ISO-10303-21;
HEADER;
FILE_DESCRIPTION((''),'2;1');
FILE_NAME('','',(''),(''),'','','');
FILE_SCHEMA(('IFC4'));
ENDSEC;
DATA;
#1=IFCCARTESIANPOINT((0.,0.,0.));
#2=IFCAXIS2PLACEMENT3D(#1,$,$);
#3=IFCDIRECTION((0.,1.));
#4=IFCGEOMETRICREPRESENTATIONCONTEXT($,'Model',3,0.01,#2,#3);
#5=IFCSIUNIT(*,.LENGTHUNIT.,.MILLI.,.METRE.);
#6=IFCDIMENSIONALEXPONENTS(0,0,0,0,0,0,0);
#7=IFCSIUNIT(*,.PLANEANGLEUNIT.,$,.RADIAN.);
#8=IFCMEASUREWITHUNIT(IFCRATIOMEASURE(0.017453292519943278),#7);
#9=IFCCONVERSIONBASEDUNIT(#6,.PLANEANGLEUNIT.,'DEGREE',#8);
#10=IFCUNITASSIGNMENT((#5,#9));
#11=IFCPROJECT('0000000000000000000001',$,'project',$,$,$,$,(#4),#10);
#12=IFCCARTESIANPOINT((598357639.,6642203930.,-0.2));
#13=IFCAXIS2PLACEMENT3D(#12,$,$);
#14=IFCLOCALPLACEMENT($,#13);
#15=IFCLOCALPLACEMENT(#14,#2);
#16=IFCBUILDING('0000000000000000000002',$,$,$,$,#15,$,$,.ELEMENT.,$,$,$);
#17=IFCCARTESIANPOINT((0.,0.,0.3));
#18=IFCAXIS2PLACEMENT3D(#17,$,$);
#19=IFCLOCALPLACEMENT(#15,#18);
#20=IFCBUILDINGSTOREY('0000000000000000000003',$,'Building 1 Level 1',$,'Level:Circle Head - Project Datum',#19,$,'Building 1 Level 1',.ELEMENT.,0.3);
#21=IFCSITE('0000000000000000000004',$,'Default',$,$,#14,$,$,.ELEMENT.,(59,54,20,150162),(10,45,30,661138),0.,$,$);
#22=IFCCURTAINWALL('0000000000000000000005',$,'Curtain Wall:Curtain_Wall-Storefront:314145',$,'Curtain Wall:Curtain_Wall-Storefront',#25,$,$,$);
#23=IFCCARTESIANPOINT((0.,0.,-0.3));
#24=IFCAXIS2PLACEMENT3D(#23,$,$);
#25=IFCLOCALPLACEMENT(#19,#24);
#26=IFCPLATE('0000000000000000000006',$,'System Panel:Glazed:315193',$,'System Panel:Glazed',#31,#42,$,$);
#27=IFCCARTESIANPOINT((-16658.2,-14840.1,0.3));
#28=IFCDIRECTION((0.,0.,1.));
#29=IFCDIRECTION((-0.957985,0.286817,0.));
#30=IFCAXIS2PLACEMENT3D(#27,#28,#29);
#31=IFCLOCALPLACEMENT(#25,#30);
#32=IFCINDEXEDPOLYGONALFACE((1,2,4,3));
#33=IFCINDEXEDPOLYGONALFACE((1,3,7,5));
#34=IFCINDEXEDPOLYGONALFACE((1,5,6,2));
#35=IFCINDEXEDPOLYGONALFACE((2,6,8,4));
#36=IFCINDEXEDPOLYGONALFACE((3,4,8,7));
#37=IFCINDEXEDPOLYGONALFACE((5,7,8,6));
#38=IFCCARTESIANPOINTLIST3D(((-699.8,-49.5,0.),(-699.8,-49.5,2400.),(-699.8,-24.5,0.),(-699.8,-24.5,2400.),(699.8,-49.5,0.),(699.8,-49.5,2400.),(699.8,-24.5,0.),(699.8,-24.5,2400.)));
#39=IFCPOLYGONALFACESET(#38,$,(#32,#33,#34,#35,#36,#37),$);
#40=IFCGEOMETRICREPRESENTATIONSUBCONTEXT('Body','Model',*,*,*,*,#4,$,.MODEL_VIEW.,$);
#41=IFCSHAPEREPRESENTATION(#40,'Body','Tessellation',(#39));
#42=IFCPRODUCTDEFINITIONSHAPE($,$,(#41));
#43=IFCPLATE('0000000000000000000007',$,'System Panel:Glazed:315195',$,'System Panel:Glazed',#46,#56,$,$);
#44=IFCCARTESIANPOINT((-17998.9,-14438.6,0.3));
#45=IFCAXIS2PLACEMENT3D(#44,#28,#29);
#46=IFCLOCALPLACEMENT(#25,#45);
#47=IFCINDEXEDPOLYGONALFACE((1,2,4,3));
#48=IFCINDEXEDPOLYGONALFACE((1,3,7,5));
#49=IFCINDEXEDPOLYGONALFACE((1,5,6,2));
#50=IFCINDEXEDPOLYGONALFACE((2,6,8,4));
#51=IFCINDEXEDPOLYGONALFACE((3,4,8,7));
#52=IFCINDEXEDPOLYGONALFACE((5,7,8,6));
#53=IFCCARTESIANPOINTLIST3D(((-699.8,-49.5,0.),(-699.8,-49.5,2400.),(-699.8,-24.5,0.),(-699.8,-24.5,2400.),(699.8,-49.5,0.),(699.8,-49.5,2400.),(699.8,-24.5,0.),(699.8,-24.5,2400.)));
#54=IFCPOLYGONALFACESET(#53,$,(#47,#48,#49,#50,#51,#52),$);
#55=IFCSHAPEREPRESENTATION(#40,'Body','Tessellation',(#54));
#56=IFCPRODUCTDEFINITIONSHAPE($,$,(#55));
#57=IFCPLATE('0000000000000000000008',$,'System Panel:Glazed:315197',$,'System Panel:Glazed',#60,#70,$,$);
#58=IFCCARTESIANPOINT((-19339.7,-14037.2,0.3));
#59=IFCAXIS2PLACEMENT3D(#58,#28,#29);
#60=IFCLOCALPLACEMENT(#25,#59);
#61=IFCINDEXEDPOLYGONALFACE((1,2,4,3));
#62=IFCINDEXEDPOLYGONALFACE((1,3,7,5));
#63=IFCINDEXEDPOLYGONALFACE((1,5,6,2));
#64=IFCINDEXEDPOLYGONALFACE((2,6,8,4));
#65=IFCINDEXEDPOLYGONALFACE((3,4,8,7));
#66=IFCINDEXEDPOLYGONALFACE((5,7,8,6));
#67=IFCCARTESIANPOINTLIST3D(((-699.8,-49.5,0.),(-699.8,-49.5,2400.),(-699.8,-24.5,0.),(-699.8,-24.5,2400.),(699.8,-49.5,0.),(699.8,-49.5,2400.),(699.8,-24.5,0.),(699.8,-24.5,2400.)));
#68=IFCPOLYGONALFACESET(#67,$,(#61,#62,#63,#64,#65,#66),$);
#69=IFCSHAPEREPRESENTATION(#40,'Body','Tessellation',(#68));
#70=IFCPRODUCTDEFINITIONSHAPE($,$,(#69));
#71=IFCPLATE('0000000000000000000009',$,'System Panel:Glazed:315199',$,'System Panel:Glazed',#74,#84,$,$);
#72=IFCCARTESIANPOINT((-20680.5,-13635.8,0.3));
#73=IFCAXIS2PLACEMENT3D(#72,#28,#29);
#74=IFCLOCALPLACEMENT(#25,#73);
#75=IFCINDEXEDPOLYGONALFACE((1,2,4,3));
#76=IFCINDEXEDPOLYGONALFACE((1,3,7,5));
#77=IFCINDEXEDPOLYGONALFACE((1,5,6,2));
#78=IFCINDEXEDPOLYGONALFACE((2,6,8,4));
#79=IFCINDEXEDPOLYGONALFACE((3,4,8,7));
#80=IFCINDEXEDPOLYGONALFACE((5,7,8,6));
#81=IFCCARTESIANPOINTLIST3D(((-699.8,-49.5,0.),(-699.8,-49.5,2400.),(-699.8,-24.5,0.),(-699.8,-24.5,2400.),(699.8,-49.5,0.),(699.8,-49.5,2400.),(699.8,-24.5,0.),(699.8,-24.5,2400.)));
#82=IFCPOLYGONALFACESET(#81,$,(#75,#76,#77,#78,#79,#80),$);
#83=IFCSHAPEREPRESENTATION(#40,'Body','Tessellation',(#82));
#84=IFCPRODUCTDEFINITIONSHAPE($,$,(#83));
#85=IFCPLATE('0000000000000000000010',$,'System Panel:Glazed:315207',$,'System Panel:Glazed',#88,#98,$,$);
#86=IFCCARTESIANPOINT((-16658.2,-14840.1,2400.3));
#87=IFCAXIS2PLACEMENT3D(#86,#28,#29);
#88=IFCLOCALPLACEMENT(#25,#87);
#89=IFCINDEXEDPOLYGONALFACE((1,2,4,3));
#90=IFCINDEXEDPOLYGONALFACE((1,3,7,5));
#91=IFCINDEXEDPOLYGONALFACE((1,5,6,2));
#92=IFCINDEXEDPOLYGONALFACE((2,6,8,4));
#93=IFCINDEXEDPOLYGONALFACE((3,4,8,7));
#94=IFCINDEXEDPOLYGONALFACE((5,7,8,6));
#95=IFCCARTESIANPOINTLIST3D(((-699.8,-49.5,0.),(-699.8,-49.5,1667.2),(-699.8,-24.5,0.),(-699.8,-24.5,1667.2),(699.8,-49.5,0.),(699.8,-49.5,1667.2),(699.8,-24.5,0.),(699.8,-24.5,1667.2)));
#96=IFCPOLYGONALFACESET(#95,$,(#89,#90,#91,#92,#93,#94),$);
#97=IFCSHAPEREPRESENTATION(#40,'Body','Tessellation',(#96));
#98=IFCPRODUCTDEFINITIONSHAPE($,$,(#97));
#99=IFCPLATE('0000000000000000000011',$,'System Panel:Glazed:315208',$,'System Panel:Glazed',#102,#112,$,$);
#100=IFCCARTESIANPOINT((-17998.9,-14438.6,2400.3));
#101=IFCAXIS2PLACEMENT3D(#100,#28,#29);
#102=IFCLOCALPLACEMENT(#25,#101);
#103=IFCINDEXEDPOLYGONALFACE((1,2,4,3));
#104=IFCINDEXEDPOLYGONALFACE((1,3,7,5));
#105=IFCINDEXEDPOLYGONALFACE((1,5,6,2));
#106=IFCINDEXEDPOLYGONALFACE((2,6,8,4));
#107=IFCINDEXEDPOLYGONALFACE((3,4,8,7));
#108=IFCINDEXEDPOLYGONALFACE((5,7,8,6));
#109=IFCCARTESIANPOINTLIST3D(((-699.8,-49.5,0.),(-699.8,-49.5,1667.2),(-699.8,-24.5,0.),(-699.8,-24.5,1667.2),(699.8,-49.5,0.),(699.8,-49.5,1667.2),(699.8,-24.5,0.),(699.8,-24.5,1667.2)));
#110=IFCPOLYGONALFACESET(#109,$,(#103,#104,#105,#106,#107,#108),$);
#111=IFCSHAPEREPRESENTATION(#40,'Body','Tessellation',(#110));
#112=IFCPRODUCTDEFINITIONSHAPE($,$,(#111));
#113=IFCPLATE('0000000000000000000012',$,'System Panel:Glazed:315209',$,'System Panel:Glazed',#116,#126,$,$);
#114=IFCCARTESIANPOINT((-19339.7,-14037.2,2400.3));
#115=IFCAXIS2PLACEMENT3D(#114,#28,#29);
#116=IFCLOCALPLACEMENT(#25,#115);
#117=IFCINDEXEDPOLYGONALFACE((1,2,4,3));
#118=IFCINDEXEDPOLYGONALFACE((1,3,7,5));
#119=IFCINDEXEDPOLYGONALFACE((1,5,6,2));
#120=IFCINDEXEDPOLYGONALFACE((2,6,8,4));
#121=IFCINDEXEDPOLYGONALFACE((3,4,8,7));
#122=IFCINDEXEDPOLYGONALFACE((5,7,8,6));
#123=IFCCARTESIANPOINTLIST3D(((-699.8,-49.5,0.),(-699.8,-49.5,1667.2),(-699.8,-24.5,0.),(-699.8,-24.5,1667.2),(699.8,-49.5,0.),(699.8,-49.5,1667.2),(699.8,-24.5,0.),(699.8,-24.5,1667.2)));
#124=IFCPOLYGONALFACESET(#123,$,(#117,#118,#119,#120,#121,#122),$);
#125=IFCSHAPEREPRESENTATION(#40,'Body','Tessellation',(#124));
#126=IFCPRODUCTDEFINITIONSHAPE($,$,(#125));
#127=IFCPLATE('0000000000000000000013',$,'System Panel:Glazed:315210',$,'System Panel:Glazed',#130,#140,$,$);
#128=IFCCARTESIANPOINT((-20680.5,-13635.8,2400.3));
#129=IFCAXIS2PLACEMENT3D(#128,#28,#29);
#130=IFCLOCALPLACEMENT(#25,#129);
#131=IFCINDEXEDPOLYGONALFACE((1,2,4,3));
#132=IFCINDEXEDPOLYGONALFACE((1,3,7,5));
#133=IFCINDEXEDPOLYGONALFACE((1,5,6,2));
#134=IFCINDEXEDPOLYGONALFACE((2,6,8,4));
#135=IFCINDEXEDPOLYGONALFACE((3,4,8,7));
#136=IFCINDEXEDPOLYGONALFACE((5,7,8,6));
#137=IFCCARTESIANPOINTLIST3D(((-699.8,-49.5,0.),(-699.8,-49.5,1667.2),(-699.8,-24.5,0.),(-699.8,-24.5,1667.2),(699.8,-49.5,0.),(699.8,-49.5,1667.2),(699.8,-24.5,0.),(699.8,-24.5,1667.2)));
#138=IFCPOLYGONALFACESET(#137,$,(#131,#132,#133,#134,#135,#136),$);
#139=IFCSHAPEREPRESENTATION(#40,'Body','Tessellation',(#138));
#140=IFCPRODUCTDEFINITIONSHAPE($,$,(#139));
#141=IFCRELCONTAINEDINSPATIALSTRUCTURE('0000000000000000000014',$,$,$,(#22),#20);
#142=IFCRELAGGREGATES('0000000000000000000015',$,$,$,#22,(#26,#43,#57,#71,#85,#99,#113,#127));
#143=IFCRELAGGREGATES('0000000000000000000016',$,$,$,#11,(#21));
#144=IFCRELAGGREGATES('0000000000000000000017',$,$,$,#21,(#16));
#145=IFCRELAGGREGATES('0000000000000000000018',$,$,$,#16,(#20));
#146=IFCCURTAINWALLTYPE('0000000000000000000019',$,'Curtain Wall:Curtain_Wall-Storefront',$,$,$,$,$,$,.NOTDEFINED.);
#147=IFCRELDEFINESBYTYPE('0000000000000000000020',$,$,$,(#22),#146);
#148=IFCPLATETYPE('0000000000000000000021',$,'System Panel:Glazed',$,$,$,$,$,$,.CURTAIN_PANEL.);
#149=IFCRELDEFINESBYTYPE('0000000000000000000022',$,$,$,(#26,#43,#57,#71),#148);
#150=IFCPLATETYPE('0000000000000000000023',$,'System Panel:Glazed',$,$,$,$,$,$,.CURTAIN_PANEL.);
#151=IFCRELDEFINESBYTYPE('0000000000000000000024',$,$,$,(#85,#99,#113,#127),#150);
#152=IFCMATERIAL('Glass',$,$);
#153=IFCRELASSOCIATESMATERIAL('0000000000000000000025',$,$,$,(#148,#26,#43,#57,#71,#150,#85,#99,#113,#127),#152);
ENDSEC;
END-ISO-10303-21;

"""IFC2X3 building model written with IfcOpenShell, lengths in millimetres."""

from ifc_helpers import new_model, entity, si_unit, converted_unit, direction, frame, frame_2d, origin, place, context, subcontext, project, spatial, rectangle, extrude, source, transform, mapped, material, type_object, type_shapes, element, aggregate, save


model = new_model("IFC2X3")

# Units and contexts
model_context = context("Model", 3, precision=0.01, world=origin(), true_north=direction((0.0, 1.0)))
body_context = subcontext(model_context, "Body", "Model", "MODEL_VIEW")
ifc_project = project(units=[si_unit("LENGTHUNIT", "METRE", prefix="MILLI"), converted_unit("PLANEANGLEUNIT", "DEGREE", entity("IfcRatioMeasure", 0.017453292519943278), si_unit("PLANEANGLEUNIT", "RADIAN"), dimensions=[0, 0, 0, 0, 0, 0, 0])], contexts=[model_context])

# Site, building, storey
site_placement = place(None, frame((598357639.0, 6642203930.0, -0.2)))
site = spatial("IfcSite", under=ifc_project, at=site_placement, Name="Default", CompositionType="ELEMENT", RefLatitude=(59, 54, 20, 150162), RefLongitude=(10, 45, 30, 661138), RefElevation=0.0)
building_placement = place(site_placement, origin())
building = spatial("IfcBuilding", under=site, at=building_placement, CompositionType="ELEMENT")
storey_placement = place(building_placement, frame((0.0, 0.0, 0.3)))
storey = spatial("IfcBuildingStorey", under=building, at=storey_placement, Name="Building 1 Level 1", ObjectType="Level:Circle Head - Project Datum", LongName="Building 1 Level 1", CompositionType="ELEMENT", Elevation=0.3)

# Curtain wall, plates
curtain_wall_type = type_object("IfcCurtainWallType", Name="Curtain Wall:Curtain_Wall-Storefront", PredefinedType="NOTDEFINED")
ifc_material = material(Name="Glass")
curtain_wall_1_placement = place(storey_placement, frame((0.0, 0.0, -0.3)))
curtain_wall_1 = element("IfcCurtainWall", 1, at=curtain_wall_1_placement, inside=storey, type_object=curtain_wall_type, Name="Curtain Wall:Curtain_Wall-Storefront:314145", ObjectType="Curtain Wall:Curtain_Wall-Storefront")
plate_type_1 = type_object("IfcPlateType", Name="System Panel:Glazed", PredefinedType="CURTAIN_PANEL", material=ifc_material)
shared_shape_1 = source(origin(), body_context, "Body", "SweptSolid", [
    extrude(rectangle(XDim=25.0, YDim=1399.6, at=frame_2d((0.0, 0.0), x_axis=(1.0, 0.0))), frame((0.0, -37.0, 0.0), z_axis=(0.0, 0.0, 1.0), x_axis=(0.0, 1.0, 0.0)), (0.0, 0.0, 1.0), 2400.0),
])
type_shapes(plate_type_1, [shared_shape_1])
plate_1_placement = place(curtain_wall_1_placement, frame((-16658.2, -14840.1, 0.3), z_axis=(0.0, 0.0, 1.0), x_axis=(-0.957985, 0.286817, 0.0)))
plate_1 = element("IfcPlate", 2, at=plate_1_placement, type_object=plate_type_1, material=ifc_material, Name="System Panel:Glazed:315193", ObjectType="System Panel:Glazed", context=body_context, shape_type="MappedRepresentation", body=[
    mapped(shared_shape_1, transform((0.0, 0.0, 0.0), scale=1.0)),
])
plate_2_placement = place(curtain_wall_1_placement, frame((-17998.9, -14438.6, 0.3), z_axis=(0.0, 0.0, 1.0), x_axis=(-0.957985, 0.286817, 0.0)))
plate_2 = element("IfcPlate", 3, at=plate_2_placement, type_object=plate_type_1, material=ifc_material, Name="System Panel:Glazed:315195", ObjectType="System Panel:Glazed", context=body_context, shape_type="MappedRepresentation", body=[
    mapped(shared_shape_1, transform((0.0, 0.0, 0.0), scale=1.0)),
])
plate_3_placement = place(curtain_wall_1_placement, frame((-19339.7, -14037.2, 0.3), z_axis=(0.0, 0.0, 1.0), x_axis=(-0.957985, 0.286817, 0.0)))
plate_3 = element("IfcPlate", 4, at=plate_3_placement, type_object=plate_type_1, material=ifc_material, Name="System Panel:Glazed:315197", ObjectType="System Panel:Glazed", context=body_context, shape_type="MappedRepresentation", body=[
    mapped(shared_shape_1, transform((0.0, 0.0, 0.0), scale=1.0)),
])
plate_4_placement = place(curtain_wall_1_placement, frame((-20680.5, -13635.8, 0.3), z_axis=(0.0, 0.0, 1.0), x_axis=(-0.957985, 0.286817, 0.0)))
plate_4 = element("IfcPlate", 5, at=plate_4_placement, type_object=plate_type_1, material=ifc_material, Name="System Panel:Glazed:315199", ObjectType="System Panel:Glazed", context=body_context, shape_type="MappedRepresentation", body=[
    mapped(shared_shape_1, transform((0.0, 0.0, 0.0), scale=1.0)),
])
plate_type_2 = type_object("IfcPlateType", Name="System Panel:Glazed", PredefinedType="CURTAIN_PANEL", material=ifc_material)
shared_shape_2 = source(origin(), body_context, "Body", "SweptSolid", [
    extrude(rectangle(XDim=25.0, YDim=1399.6, at=frame_2d((0.0, 0.0), x_axis=(1.0, 0.0))), frame((0.0, -37.0, 0.0), z_axis=(0.0, 0.0, 1.0), x_axis=(0.0, 1.0, 0.0)), (0.0, 0.0, 1.0), 1667.2),
])
type_shapes(plate_type_2, [shared_shape_2])
plate_5_placement = place(curtain_wall_1_placement, frame((-16658.2, -14840.1, 2400.3), z_axis=(0.0, 0.0, 1.0), x_axis=(-0.957985, 0.286817, 0.0)))
plate_5 = element("IfcPlate", 6, at=plate_5_placement, type_object=plate_type_2, material=ifc_material, Name="System Panel:Glazed:315207", ObjectType="System Panel:Glazed", context=body_context, shape_type="MappedRepresentation", body=[
    mapped(shared_shape_2, transform((0.0, 0.0, 0.0), scale=1.0)),
])
plate_6_placement = place(curtain_wall_1_placement, frame((-17998.9, -14438.6, 2400.3), z_axis=(0.0, 0.0, 1.0), x_axis=(-0.957985, 0.286817, 0.0)))
plate_6 = element("IfcPlate", 7, at=plate_6_placement, type_object=plate_type_2, material=ifc_material, Name="System Panel:Glazed:315208", ObjectType="System Panel:Glazed", context=body_context, shape_type="MappedRepresentation", body=[
    mapped(shared_shape_2, transform((0.0, 0.0, 0.0), scale=1.0)),
])
plate_7_placement = place(curtain_wall_1_placement, frame((-19339.7, -14037.2, 2400.3), z_axis=(0.0, 0.0, 1.0), x_axis=(-0.957985, 0.286817, 0.0)))
plate_7 = element("IfcPlate", 8, at=plate_7_placement, type_object=plate_type_2, material=ifc_material, Name="System Panel:Glazed:315209", ObjectType="System Panel:Glazed", context=body_context, shape_type="MappedRepresentation", body=[
    mapped(shared_shape_2, transform((0.0, 0.0, 0.0), scale=1.0)),
])
plate_8_placement = place(curtain_wall_1_placement, frame((-20680.5, -13635.8, 2400.3), z_axis=(0.0, 0.0, 1.0), x_axis=(-0.957985, 0.286817, 0.0)))
plate_8 = element("IfcPlate", 9, at=plate_8_placement, type_object=plate_type_2, material=ifc_material, Name="System Panel:Glazed:315210", ObjectType="System Panel:Glazed", context=body_context, shape_type="MappedRepresentation", body=[
    mapped(shared_shape_2, transform((0.0, 0.0, 0.0), scale=1.0)),
])
aggregate(curtain_wall_1, [plate_1, plate_2, plate_3, plate_4, plate_5, plate_6, plate_7, plate_8])

save(model, "model.ifc")
